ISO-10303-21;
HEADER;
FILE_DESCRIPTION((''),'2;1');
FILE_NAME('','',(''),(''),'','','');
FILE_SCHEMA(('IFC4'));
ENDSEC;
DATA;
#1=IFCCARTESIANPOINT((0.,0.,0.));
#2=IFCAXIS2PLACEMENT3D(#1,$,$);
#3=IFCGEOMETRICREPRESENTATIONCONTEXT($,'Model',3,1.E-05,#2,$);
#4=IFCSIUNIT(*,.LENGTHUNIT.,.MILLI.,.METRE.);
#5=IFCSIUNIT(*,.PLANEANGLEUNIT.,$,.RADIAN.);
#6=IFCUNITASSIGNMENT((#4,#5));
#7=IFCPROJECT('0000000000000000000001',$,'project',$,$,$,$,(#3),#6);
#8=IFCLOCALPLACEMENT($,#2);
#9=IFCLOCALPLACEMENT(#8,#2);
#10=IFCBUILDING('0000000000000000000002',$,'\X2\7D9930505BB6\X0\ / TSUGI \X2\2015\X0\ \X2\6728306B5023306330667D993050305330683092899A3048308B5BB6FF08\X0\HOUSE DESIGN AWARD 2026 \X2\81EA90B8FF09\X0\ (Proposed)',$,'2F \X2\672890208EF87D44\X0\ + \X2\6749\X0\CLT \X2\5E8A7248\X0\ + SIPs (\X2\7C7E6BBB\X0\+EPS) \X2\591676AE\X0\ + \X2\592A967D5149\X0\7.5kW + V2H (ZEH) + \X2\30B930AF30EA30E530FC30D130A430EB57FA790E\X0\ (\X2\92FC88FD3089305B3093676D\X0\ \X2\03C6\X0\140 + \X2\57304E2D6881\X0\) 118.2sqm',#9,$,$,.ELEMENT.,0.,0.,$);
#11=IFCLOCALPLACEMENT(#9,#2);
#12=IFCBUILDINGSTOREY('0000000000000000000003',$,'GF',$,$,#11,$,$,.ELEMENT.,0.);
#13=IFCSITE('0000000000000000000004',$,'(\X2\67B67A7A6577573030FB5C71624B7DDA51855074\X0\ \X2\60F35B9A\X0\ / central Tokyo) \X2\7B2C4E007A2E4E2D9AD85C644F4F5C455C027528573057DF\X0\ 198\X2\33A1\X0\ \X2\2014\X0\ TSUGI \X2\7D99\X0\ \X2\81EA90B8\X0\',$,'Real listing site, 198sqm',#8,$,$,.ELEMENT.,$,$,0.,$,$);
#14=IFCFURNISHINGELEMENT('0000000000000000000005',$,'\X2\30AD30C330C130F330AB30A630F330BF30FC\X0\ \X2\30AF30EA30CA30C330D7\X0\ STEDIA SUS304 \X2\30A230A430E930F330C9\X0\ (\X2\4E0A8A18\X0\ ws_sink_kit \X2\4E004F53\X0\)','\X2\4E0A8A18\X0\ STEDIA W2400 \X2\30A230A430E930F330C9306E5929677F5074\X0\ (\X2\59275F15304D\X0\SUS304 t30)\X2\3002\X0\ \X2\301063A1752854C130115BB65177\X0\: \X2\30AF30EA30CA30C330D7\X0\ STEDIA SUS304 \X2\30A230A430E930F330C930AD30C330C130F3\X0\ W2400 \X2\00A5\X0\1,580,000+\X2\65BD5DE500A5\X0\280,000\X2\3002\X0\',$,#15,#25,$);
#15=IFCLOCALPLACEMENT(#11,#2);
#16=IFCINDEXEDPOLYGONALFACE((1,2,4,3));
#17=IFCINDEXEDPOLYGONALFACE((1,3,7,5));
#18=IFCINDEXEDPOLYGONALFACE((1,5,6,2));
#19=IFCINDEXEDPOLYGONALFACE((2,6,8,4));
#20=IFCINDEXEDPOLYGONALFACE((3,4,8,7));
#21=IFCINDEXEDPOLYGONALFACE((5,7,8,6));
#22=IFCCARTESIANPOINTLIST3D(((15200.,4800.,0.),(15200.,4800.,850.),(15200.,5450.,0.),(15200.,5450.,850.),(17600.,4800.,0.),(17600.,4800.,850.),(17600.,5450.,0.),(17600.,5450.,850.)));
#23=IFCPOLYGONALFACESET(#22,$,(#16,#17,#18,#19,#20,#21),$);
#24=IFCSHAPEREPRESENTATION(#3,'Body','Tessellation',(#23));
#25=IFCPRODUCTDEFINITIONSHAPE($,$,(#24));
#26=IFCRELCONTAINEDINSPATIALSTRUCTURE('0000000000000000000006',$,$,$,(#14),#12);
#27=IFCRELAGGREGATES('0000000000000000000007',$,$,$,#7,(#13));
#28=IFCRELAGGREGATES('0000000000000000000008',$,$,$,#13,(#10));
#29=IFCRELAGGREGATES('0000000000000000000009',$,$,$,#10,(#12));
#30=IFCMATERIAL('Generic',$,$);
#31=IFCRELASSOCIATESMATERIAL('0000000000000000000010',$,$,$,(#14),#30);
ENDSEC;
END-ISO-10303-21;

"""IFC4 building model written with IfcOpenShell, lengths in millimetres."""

from ifc_helpers import new_model, si_unit, frame, frame_2d, origin, place, context, project, spatial, rectangle, extrude, material, element, save


model = new_model("IFC4")

# Units and contexts
model_context = context("Model", 3, precision=1e-05, world=origin())
ifc_project = project(units=[si_unit("LENGTHUNIT", "METRE", prefix="MILLI"), si_unit("PLANEANGLEUNIT", "RADIAN")], contexts=[model_context])

# Site, building, storey
site_placement = place(None, origin())
site = spatial("IfcSite", under=ifc_project, at=site_placement, Name="(架空敷地・山手線内側 想定 / central Tokyo) 第一種中高層住居専用地域 198㎡ — TSUGI 継 自邸", ObjectType="Real listing site, 198sqm", CompositionType="ELEMENT", RefElevation=0.0)
building_placement = place(site_placement, origin())
building = spatial("IfcBuilding", under=site, at=building_placement, Name="継ぐ家 / TSUGI ― 木に倣って継ぐことを覚える家（HOUSE DESIGN AWARD 2026 自邸） (Proposed)", ObjectType="2F 木造軸組 + 杉CLT 床版 + SIPs (籾殻+EPS) 外皮 + 太陽光7.5kW + V2H (ZEH) + スクリューパイル基礎 (鋼製らせん杭 φ140 + 地中梁) 118.2sqm", CompositionType="ELEMENT", ElevationOfRefHeight=0.0, ElevationOfTerrain=0.0)
storey_placement = place(building_placement, origin())
storey = spatial("IfcBuildingStorey", under=building, at=storey_placement, Name="GF", CompositionType="ELEMENT", Elevation=0.0)

# Shared definitions
ifc_material_1 = material(Name="Generic")

# Furnishing element
furnishing_1_placement = place(storey_placement, frame((7600.0, 2400.0, 0.0)))
element("IfcFurnishingElement", 1, at=furnishing_1_placement, inside=storey, material=ifc_material_1, Name="キッチンカウンター クリナップ STEDIA SUS304 アイランド (上記 ws_sink_kit 一体)", Description="上記 STEDIA W2400 アイランドの天板側 (大引きSUS304 t30)。 【採用品】家具: クリナップ STEDIA SUS304 アイランドキッチン W2400 ¥1,580,000+施工¥280,000。", context=model_context, shape_type="SweptSolid", body=[
    extrude(rectangle(XDim=2400.0, YDim=650.0, at=frame_2d((1200.0, 325.0))), frame((7600.0, 2400.0, 0.0)), (0.0, 0.0, 1.0), 850.0),
])

save(model, "model.ifc")
